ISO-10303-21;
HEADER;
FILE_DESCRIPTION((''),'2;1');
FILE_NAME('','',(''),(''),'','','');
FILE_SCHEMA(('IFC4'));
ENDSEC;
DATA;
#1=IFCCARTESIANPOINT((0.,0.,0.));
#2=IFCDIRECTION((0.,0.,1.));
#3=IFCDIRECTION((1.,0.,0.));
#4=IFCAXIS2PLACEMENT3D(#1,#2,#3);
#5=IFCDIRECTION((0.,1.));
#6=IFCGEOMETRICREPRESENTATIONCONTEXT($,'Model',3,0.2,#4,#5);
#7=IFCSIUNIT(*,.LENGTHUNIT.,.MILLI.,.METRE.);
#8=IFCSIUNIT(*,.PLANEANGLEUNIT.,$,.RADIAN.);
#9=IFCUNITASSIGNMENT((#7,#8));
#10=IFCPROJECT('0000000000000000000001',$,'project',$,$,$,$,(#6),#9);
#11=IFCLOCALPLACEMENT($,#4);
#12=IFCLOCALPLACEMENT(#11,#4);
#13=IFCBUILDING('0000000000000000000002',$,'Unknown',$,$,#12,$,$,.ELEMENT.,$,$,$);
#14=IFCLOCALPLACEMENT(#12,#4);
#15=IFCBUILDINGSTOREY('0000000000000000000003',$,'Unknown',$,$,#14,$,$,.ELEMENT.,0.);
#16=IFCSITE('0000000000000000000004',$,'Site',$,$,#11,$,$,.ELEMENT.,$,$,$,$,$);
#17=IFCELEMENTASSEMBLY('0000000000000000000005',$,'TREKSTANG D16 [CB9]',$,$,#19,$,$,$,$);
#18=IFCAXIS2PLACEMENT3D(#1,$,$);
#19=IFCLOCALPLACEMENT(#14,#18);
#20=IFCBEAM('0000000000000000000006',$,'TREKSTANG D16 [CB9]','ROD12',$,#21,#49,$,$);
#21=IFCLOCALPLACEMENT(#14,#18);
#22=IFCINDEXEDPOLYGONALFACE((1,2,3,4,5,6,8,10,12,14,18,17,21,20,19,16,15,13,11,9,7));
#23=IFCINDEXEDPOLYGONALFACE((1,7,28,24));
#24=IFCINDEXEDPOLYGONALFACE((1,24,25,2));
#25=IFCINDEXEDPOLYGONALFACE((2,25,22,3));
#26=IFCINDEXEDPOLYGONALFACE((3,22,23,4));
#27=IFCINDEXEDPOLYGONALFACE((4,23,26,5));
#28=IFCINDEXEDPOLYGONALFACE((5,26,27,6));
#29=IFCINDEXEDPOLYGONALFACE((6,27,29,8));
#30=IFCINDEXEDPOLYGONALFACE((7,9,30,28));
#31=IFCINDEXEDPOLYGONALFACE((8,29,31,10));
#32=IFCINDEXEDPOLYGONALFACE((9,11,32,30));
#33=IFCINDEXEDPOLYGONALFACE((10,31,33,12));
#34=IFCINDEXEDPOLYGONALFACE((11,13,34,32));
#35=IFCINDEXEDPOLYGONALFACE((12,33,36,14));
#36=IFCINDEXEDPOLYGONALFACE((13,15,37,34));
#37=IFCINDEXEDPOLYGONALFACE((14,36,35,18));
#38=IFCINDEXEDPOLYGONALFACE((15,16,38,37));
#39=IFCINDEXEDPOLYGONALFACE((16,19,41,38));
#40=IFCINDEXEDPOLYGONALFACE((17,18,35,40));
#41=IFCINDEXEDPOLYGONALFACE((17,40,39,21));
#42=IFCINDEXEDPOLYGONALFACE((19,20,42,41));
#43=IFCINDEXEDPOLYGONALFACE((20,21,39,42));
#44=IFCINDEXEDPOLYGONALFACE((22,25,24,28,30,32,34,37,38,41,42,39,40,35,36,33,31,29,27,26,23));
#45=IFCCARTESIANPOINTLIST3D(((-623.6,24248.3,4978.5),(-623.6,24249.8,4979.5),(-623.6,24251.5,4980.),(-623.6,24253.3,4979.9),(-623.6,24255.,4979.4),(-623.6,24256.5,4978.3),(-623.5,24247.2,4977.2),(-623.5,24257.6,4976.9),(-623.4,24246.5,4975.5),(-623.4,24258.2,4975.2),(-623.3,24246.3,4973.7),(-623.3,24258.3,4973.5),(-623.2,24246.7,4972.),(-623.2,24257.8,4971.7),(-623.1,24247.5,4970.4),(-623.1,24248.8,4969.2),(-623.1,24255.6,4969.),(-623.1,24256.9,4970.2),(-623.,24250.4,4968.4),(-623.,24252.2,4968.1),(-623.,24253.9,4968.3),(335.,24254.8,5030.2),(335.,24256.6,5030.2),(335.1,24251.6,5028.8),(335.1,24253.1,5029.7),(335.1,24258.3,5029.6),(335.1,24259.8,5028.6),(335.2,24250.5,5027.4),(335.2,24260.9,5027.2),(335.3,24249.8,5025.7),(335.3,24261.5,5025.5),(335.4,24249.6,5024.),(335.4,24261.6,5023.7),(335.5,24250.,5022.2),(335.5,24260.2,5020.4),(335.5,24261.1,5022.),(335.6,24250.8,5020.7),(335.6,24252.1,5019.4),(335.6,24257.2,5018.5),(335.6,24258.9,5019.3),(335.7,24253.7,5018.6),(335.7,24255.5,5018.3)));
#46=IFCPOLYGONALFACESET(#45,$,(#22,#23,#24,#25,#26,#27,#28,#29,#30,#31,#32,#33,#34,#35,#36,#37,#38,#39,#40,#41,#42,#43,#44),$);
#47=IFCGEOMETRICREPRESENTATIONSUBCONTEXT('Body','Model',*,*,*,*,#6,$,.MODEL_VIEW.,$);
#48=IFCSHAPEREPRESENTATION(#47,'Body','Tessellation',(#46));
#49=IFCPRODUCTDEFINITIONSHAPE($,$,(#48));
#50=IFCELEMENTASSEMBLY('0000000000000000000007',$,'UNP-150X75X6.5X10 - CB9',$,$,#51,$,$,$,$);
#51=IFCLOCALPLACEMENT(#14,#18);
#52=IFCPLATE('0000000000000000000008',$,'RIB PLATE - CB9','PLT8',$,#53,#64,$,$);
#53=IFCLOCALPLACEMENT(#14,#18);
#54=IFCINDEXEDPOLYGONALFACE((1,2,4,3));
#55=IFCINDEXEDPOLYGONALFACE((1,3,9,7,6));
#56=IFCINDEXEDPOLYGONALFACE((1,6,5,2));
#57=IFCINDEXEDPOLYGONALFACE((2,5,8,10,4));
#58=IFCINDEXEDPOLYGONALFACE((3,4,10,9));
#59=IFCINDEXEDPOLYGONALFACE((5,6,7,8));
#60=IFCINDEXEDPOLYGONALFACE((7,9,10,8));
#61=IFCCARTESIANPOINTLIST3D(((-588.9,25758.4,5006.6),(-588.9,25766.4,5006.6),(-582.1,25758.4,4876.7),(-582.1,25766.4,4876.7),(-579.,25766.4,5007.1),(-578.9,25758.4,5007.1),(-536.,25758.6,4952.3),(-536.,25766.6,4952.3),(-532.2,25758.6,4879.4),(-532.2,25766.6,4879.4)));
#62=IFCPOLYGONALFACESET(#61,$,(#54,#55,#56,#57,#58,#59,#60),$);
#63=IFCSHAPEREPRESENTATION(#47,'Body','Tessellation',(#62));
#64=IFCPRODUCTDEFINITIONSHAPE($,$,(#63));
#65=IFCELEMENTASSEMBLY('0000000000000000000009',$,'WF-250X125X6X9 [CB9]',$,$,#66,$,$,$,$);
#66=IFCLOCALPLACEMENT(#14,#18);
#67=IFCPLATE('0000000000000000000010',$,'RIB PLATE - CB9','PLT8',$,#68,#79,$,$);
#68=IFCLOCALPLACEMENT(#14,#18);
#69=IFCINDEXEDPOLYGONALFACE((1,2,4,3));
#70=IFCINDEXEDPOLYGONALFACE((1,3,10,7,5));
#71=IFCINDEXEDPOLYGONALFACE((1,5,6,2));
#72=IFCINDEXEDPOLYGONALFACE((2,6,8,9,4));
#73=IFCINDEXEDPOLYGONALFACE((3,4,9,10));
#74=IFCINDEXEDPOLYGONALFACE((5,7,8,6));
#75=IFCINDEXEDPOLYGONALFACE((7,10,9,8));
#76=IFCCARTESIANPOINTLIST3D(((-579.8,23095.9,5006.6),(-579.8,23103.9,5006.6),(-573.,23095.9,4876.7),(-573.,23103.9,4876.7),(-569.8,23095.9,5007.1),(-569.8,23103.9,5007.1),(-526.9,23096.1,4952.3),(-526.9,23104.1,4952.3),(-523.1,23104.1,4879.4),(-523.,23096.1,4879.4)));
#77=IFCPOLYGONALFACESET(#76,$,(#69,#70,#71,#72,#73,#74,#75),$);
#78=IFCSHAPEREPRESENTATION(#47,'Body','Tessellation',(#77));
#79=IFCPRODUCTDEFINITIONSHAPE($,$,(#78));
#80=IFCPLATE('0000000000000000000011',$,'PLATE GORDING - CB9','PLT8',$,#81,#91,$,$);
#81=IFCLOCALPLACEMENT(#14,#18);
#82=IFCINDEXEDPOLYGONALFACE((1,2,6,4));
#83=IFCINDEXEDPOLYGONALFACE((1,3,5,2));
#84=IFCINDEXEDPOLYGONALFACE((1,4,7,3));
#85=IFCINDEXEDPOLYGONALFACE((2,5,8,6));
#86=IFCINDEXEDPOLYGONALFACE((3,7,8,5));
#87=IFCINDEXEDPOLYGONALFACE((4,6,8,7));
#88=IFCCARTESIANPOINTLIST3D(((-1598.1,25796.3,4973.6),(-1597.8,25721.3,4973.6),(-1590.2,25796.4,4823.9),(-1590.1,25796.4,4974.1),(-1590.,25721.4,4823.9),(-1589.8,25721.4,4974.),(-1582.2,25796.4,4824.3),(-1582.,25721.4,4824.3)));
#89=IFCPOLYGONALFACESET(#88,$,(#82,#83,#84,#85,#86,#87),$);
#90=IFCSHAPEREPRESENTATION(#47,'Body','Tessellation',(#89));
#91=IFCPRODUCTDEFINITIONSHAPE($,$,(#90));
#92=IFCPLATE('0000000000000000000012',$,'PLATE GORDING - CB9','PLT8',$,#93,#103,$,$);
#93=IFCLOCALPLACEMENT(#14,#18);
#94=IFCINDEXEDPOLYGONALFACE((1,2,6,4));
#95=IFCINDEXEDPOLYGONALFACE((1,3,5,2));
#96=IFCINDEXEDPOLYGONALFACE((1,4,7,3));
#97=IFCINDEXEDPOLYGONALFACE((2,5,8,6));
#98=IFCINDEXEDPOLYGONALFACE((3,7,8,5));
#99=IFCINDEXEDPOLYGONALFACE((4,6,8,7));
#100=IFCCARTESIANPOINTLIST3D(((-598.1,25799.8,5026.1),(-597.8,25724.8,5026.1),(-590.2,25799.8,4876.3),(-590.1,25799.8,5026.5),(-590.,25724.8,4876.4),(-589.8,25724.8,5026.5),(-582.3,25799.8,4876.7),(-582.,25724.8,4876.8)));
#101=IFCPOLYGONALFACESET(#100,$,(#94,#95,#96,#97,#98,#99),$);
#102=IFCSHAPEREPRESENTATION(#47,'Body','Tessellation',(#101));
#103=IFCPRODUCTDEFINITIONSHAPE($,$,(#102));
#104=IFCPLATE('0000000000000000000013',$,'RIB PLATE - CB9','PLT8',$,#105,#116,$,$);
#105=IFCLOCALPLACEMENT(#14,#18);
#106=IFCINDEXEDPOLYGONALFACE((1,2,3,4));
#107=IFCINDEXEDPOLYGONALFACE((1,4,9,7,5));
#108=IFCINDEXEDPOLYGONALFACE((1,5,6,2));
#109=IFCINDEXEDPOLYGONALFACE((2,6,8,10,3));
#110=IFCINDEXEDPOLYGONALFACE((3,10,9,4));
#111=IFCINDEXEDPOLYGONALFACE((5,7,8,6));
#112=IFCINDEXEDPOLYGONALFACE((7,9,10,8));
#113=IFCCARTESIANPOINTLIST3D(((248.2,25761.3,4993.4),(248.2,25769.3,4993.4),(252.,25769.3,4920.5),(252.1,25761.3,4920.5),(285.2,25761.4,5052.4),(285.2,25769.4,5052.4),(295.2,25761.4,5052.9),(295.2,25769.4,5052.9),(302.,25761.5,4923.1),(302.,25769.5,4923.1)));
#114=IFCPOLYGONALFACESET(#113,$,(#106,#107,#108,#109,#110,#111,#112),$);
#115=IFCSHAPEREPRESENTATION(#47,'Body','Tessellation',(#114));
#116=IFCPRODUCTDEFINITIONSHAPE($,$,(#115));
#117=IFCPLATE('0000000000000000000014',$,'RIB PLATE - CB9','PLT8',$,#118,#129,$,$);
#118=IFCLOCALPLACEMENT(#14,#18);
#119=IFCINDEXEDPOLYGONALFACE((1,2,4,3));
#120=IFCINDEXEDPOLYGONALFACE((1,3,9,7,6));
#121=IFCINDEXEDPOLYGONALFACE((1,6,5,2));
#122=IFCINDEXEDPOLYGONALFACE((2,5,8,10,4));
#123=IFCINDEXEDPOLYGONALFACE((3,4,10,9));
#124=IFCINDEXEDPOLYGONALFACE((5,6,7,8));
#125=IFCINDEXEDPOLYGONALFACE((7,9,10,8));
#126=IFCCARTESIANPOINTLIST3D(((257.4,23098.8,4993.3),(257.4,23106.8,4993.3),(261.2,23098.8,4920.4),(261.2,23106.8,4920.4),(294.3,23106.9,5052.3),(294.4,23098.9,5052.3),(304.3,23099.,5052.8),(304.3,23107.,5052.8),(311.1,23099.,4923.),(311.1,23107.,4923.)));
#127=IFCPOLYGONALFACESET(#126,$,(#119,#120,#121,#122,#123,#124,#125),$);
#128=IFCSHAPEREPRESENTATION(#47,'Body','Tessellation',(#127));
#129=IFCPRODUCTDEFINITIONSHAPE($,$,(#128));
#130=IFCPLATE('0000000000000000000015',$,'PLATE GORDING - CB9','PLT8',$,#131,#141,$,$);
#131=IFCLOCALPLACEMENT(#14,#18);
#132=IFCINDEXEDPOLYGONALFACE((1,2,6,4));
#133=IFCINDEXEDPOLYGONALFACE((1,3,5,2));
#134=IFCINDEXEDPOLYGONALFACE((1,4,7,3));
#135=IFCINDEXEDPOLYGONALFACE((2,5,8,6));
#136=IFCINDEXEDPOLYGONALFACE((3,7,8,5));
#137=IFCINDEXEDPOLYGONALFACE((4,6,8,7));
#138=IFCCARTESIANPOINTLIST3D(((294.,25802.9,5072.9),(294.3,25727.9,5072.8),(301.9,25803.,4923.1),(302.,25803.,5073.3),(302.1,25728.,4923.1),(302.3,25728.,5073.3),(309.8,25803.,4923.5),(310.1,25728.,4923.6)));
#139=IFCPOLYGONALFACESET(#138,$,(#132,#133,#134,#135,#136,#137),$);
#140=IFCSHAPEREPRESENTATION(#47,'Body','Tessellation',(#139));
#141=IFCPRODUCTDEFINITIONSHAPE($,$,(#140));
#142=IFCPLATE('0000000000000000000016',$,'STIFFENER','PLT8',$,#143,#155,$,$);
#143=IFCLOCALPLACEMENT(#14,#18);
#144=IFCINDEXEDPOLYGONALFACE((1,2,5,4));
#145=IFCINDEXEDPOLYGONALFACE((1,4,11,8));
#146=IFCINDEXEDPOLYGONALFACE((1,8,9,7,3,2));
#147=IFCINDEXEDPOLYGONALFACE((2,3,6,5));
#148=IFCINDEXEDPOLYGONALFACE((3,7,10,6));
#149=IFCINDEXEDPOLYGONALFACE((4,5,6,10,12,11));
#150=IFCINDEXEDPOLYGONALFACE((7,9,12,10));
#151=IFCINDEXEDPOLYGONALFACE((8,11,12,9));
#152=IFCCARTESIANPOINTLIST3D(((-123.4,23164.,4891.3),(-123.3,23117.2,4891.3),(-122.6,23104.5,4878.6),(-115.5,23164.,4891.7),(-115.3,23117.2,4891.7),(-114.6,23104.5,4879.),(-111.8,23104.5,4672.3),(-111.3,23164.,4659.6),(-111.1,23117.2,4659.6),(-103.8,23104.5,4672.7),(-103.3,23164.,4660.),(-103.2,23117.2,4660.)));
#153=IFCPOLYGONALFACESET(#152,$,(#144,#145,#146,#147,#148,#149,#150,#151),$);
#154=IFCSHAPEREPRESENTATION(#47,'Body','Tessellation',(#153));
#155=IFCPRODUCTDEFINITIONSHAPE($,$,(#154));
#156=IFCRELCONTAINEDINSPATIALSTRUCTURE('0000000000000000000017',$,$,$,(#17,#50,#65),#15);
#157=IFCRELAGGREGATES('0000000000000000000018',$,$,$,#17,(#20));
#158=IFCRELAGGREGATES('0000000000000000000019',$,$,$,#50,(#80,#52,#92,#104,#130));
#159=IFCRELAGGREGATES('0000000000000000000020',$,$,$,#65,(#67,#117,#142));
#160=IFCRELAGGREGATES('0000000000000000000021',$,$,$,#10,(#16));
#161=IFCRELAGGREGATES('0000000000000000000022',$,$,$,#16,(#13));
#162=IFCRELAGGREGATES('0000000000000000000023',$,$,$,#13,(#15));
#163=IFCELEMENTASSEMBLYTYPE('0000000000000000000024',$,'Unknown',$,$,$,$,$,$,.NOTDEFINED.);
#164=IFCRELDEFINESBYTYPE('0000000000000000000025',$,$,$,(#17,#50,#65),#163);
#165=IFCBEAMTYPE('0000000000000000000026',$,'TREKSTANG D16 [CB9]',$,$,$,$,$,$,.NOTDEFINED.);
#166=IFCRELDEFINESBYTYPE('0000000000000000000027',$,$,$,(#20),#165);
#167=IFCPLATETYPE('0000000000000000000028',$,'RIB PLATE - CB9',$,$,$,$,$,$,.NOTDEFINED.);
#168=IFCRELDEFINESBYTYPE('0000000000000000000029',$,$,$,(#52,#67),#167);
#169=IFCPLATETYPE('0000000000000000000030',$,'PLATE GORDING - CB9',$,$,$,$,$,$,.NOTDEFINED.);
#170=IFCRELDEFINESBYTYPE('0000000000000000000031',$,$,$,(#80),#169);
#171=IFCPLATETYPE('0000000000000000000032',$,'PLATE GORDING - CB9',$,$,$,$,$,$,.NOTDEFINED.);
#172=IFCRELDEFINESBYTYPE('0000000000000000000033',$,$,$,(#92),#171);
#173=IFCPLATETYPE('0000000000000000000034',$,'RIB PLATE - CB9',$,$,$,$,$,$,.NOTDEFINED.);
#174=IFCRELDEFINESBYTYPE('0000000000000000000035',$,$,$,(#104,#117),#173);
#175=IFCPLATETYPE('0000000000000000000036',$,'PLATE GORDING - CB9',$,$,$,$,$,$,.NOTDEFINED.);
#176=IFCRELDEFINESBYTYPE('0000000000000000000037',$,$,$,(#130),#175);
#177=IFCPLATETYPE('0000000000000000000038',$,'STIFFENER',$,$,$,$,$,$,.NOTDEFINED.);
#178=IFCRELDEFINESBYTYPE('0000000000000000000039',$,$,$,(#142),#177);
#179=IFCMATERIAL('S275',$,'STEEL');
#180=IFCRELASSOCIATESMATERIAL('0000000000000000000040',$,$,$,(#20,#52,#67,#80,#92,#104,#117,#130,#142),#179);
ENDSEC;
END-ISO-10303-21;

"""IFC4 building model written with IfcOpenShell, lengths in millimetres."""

from ifc_helpers import new_model, si_unit, direction, frame, origin_with_axes, origin_2d_with_axis, place, context, subcontext, project, spatial, line, indexed_curve, circle, outline, extrude, material, material_profile, profile_set, profile_usage, type_object, element, aggregate, save


model = new_model("IFC4")

# Units and contexts
model_context = context("Model", 3, precision=0.2, world=origin_with_axes(), true_north=direction((0.0, 1.0)))
body_context = subcontext(model_context, "Body", "Model", "MODEL_VIEW")
ifc_project = project(units=[si_unit("LENGTHUNIT", "METRE", prefix="MILLI"), si_unit("PLANEANGLEUNIT", "RADIAN")], contexts=[model_context])

# Site, building, storey
site_placement = place(None, origin_with_axes())
site = spatial("IfcSite", under=ifc_project, at=site_placement, Name="Site", CompositionType="ELEMENT")
building_placement = place(site_placement, origin_with_axes())
building = spatial("IfcBuilding", under=site, at=building_placement, Name="Unknown", CompositionType="ELEMENT")
storey_placement = place(building_placement, origin_with_axes())
storey = spatial("IfcBuildingStorey", under=building, at=storey_placement, Name="Unknown", CompositionType="ELEMENT", Elevation=0.0)

# Element assembly, beam
element_assembly_type = type_object("IfcElementAssemblyType", Name="Unknown", PredefinedType="NOTDEFINED")
ifc_material_1 = material(Name="S275", Category="STEEL")
assembly_1_placement = place(storey_placement, frame((-623.3, 24252.3, 4974.0), z_axis=(0.006191, -0.998614, -0.052264), x_axis=(0.998624, 0.003452, 0.052336)))
assembly_1 = element("IfcElementAssembly", 1, at=assembly_1_placement, inside=storey, type_object=element_assembly_type, Name="TREKSTANG D16 [CB9]")
ifc_material_profile_1 = material_profile(ifc_material_1, circle(Radius=6.0, at=origin_2d_with_axis()), Name="ROD12")
ifc_profile_set_1 = profile_set([ifc_material_profile_1])
ifc_profile_usage_1 = profile_usage(ifc_profile_set_1, cardinal=5)
beam_type_1 = type_object("IfcBeamType", Name="TREKSTANG D16 [CB9]", PredefinedType="NOTDEFINED")
beam_1_placement = place(assembly_1_placement, origin_with_axes())
beam_1 = element("IfcBeam", 2, at=beam_1_placement, type_object=beam_type_1, material=ifc_profile_usage_1, Name="TREKSTANG D16 [CB9]", Description="ROD12", context=body_context, shape_type="SolidModel", body=[
    extrude(circle(Radius=6.0, at=origin_2d_with_axis()), frame((0.0, 0.0, 0.0), z_axis=(-1.0, 0.0, 0.0), x_axis=(0.0, 0.0, 1.0)), (0.0, 0.0, -1.0), 960.0),
])
aggregate(assembly_1, [beam_1])

# Element assemblies, plates
assembly_2_placement = place(storey_placement, frame((-3132.1, 25753.6, 4668.0), z_axis=(0.003456, -0.999994, 0.0), x_axis=(0.998624, 0.003452, 0.052336)))
assembly_2 = element("IfcElementAssembly", 3, at=assembly_2_placement, inside=storey, type_object=element_assembly_type, Name="UNP-150X75X6.5X10 - CB9")
ifc_material_profile_2 = material_profile(ifc_material_1, outline(indexed_curve([(0.0, 0.0), (130.0, 0.0), (130.0, 10.0), (73.0, 50.0), (0.0, 50.0)], segments=[line(1, 2, 3, 4, 5, 1)])), Name="PLT8")
ifc_profile_set_2 = profile_set([ifc_material_profile_2])
ifc_profile_usage_2 = profile_usage(ifc_profile_set_2, cardinal=5)
plate_type_1 = type_object("IfcPlateType", Name="RIB PLATE - CB9", PredefinedType="NOTDEFINED")
plate_1_placement = place(assembly_2_placement, frame((2557.4, 75.0, 0.0), z_axis=(0.0, 0.0, -1.0), x_axis=(0.0, 1.0, 0.0)))
plate_1 = element("IfcPlate", 4, at=plate_1_placement, type_object=plate_type_1, material=ifc_profile_usage_2, Name="RIB PLATE - CB9", Description="PLT8", context=body_context, shape_type="SolidModel", body=[
    extrude(outline(indexed_curve([(0.0, 0.0), (130.0, 0.0), (130.0, 10.0), (73.0, 50.0), (0.0, 50.0)], segments=[line(1, 2, 3, 4, 5, 1)])), frame((0.0, 0.0, 4.0), z_axis=(0.0, 0.0, 1.0), x_axis=(1.0, 0.0, 0.0)), (0.0, 0.0, -1.0), 8.0),
])
assembly_3_placement = place(storey_placement, frame((-2268.9, 23094.1, 4662.7), z_axis=(0.003456, -0.999994, 0.0), x_axis=(0.998624, 0.003452, 0.052336)))
assembly_3 = element("IfcElementAssembly", 5, at=assembly_3_placement, inside=storey, type_object=element_assembly_type, Name="WF-250X125X6X9 [CB9]")
plate_2_placement = place(assembly_3_placement, frame((1704.8, 125.0, 0.0), z_axis=(0.0, 0.0, -1.0), x_axis=(0.0, 1.0, 0.0)))
plate_2 = element("IfcPlate", 6, at=plate_2_placement, type_object=plate_type_1, material=ifc_profile_usage_2, Name="RIB PLATE - CB9", Description="PLT8", context=body_context, shape_type="SolidModel", body=[
    extrude(outline(indexed_curve([(0.0, 0.0), (130.0, 0.0), (130.0, 10.0), (73.0, 50.0), (0.0, 50.0)], segments=[line(1, 2, 3, 4, 5, 1)])), frame((0.0, 0.0, 4.0), z_axis=(0.0, 0.0, 1.0), x_axis=(1.0, 0.0, 0.0)), (0.0, 0.0, -1.0), 8.0),
])

# Plates
ifc_material_profile_3 = material_profile(ifc_material_1, outline(indexed_curve([(0.0, 0.0), (149.9, 0.0), (150.0, 75.0), (0.0, 75.0)], segments=[line(1, 2, 3, 4, 1)])), Name="PLT8")
ifc_profile_set_3 = profile_set([ifc_material_profile_3])
ifc_profile_usage_3 = profile_usage(ifc_profile_set_3, cardinal=5)
plate_type_2 = type_object("IfcPlateType", Name="PLATE GORDING - CB9", PredefinedType="NOTDEFINED")
plate_3_placement = place(assembly_2_placement, frame((1552.0, 224.9, 37.5), z_axis=(1.0, 0.0, 0.0), x_axis=(0.0, -1.0, 0.0)))
plate_3 = element("IfcPlate", 7, at=plate_3_placement, type_object=plate_type_2, material=ifc_profile_usage_3, Name="PLATE GORDING - CB9", Description="PLT8", context=body_context, shape_type="SolidModel", body=[
    extrude(outline(indexed_curve([(0.0, 0.0), (149.9, 0.0), (150.0, 75.0), (0.0, 75.0)], segments=[line(1, 2, 3, 4, 1)])), frame((0.0, 0.0, 4.0), z_axis=(0.0, 0.0, 1.0), x_axis=(1.0, 0.0, 0.0)), (0.0, 0.0, -1.0), 8.0),
])
ifc_material_profile_4 = material_profile(ifc_material_1, outline(indexed_curve([(0.0, 0.0), (149.9, 0.0), (150.0, 75.0), (0.0, 75.0)], segments=[line(1, 2, 3, 4, 1)])), Name="PLT8")
ifc_profile_set_4 = profile_set([ifc_material_profile_4])
ifc_profile_usage_4 = profile_usage(ifc_profile_set_4, cardinal=5)
plate_type_3 = type_object("IfcPlateType", Name="PLATE GORDING - CB9", PredefinedType="NOTDEFINED")
plate_4_placement = place(assembly_2_placement, frame((2553.4, 225.0, 37.6), z_axis=(1.0, 0.0, 0.0), x_axis=(0.0, -1.0, 0.0)))
plate_4 = element("IfcPlate", 8, at=plate_4_placement, type_object=plate_type_3, material=ifc_profile_usage_4, Name="PLATE GORDING - CB9", Description="PLT8", context=body_context, shape_type="SolidModel", body=[
    extrude(outline(indexed_curve([(0.0, 0.0), (149.9, 0.0), (150.0, 75.0), (0.0, 75.0)], segments=[line(1, 2, 3, 4, 1)])), frame((0.0, 0.0, 4.0), z_axis=(0.0, 0.0, 1.0), x_axis=(1.0, 0.0, 0.0)), (0.0, 0.0, -1.0), 8.0),
])
ifc_material_profile_5 = material_profile(ifc_material_1, outline(indexed_curve([(0.0, 0.0), (130.0, 0.0), (130.0, 50.0), (57.0, 50.0), (0.0, 10.0)], segments=[line(1, 2, 3, 4, 5, 1)])), Name="PLT8")
ifc_profile_set_5 = profile_set([ifc_material_profile_5])
ifc_profile_usage_5 = profile_usage(ifc_profile_set_5, cardinal=5)
plate_type_4 = type_object("IfcPlateType", Name="RIB PLATE - CB9", PredefinedType="NOTDEFINED")
plate_5_placement = place(assembly_2_placement, frame((3442.7, 205.0, 0.0), z_axis=(0.0, 0.0, -1.0), x_axis=(0.0, -1.0, 0.0)))
plate_5 = element("IfcPlate", 9, at=plate_5_placement, type_object=plate_type_4, material=ifc_profile_usage_5, Name="RIB PLATE - CB9", Description="PLT8", context=body_context, shape_type="SolidModel", body=[
    extrude(outline(indexed_curve([(0.0, 0.0), (130.0, 0.0), (130.0, 50.0), (57.0, 50.0), (0.0, 10.0)], segments=[line(1, 2, 3, 4, 5, 1)])), frame((0.0, 0.0, 4.0), z_axis=(0.0, 0.0, 1.0), x_axis=(1.0, 0.0, 0.0)), (0.0, 0.0, -1.0), 8.0),
])
plate_6_placement = place(assembly_3_placement, frame((2590.2, 254.9, 0.0), z_axis=(0.0, 0.0, -1.0), x_axis=(0.0, -1.0, 0.0)))
plate_6 = element("IfcPlate", 10, at=plate_6_placement, type_object=plate_type_4, material=ifc_profile_usage_5, Name="RIB PLATE - CB9", Description="PLT8", context=body_context, shape_type="SolidModel", body=[
    extrude(outline(indexed_curve([(0.0, 0.0), (130.0, 0.0), (130.0, 50.0), (57.0, 50.0), (0.0, 10.0)], segments=[line(1, 2, 3, 4, 5, 1)])), frame((0.0, 0.0, 4.0), z_axis=(0.0, 0.0, 1.0), x_axis=(1.0, 0.0, 0.0)), (0.0, 0.0, -1.0), 8.0),
])
ifc_material_profile_6 = material_profile(ifc_material_1, outline(indexed_curve([(0.0, 0.0), (75.0, 0.0), (75.1, 149.9), (0.1, 150.0)], segments=[line(1, 2, 3, 4, 1)])), Name="PLT8")
ifc_profile_set_6 = profile_set([ifc_material_profile_6])
ifc_profile_usage_6 = profile_usage(ifc_profile_set_6, cardinal=5)
plate_type_5 = type_object("IfcPlateType", Name="PLATE GORDING - CB9", PredefinedType="NOTDEFINED")
plate_7_placement = place(assembly_2_placement, frame((3446.7, 225.0, -37.5), z_axis=(1.0, 0.0, 0.0), x_axis=(0.0, -0.000572, 1.0)))
plate_7 = element("IfcPlate", 11, at=plate_7_placement, type_object=plate_type_5, material=ifc_profile_usage_6, Name="PLATE GORDING - CB9", Description="PLT8", context=body_context, shape_type="SolidModel", body=[
    extrude(outline(indexed_curve([(0.0, 0.0), (75.0, 0.0), (75.1, 149.9), (0.1, 150.0)], segments=[line(1, 2, 3, 4, 1)])), frame((0.0, 0.0, 4.0), z_axis=(0.0, 0.0, 1.0), x_axis=(1.0, 0.0, 0.0)), (0.0, 0.0, -1.0), 8.0),
])
aggregate(assembly_2, [plate_3, plate_1, plate_4, plate_5, plate_7])
ifc_material_profile_7 = material_profile(ifc_material_1, outline(indexed_curve([(0.0, 12.7), (12.7, 0.0), (59.5, 0.0), (59.5, 232.0), (12.7, 232.0), (0.0, 219.3)], segments=[line(1, 2, 3, 4, 5, 6, 1)])), Name="PLT8")
ifc_profile_set_7 = profile_set([ifc_material_profile_7])
ifc_profile_usage_7 = profile_usage(ifc_profile_set_7, cardinal=2)
plate_type_6 = type_object("IfcPlateType", Name="STIFFENER", PredefinedType="NOTDEFINED")
plate_8_placement = place(assembly_3_placement, frame((2158.7, 116.0, -3.0), z_axis=(-1.0, 0.0, 0.0), x_axis=(0.0, 0.0, -1.0)))
plate_8 = element("IfcPlate", 12, at=plate_8_placement, type_object=plate_type_6, material=ifc_profile_usage_7, Name="STIFFENER", Description="PLT8", context=body_context, shape_type="SolidModel", body=[
    extrude(outline(indexed_curve([(0.0, 12.7), (12.7, 0.0), (59.5, 0.0), (59.5, 232.0), (12.7, 232.0), (0.0, 219.3)], segments=[line(1, 2, 3, 4, 5, 6, 1)])), frame((0.0, 0.0, 4.0), z_axis=(0.0, 0.0, 1.0), x_axis=(1.0, 0.0, 0.0)), (0.0, 0.0, -1.0), 8.0),
])
aggregate(assembly_3, [plate_2, plate_6, plate_8])

save(model, "model.ifc")
